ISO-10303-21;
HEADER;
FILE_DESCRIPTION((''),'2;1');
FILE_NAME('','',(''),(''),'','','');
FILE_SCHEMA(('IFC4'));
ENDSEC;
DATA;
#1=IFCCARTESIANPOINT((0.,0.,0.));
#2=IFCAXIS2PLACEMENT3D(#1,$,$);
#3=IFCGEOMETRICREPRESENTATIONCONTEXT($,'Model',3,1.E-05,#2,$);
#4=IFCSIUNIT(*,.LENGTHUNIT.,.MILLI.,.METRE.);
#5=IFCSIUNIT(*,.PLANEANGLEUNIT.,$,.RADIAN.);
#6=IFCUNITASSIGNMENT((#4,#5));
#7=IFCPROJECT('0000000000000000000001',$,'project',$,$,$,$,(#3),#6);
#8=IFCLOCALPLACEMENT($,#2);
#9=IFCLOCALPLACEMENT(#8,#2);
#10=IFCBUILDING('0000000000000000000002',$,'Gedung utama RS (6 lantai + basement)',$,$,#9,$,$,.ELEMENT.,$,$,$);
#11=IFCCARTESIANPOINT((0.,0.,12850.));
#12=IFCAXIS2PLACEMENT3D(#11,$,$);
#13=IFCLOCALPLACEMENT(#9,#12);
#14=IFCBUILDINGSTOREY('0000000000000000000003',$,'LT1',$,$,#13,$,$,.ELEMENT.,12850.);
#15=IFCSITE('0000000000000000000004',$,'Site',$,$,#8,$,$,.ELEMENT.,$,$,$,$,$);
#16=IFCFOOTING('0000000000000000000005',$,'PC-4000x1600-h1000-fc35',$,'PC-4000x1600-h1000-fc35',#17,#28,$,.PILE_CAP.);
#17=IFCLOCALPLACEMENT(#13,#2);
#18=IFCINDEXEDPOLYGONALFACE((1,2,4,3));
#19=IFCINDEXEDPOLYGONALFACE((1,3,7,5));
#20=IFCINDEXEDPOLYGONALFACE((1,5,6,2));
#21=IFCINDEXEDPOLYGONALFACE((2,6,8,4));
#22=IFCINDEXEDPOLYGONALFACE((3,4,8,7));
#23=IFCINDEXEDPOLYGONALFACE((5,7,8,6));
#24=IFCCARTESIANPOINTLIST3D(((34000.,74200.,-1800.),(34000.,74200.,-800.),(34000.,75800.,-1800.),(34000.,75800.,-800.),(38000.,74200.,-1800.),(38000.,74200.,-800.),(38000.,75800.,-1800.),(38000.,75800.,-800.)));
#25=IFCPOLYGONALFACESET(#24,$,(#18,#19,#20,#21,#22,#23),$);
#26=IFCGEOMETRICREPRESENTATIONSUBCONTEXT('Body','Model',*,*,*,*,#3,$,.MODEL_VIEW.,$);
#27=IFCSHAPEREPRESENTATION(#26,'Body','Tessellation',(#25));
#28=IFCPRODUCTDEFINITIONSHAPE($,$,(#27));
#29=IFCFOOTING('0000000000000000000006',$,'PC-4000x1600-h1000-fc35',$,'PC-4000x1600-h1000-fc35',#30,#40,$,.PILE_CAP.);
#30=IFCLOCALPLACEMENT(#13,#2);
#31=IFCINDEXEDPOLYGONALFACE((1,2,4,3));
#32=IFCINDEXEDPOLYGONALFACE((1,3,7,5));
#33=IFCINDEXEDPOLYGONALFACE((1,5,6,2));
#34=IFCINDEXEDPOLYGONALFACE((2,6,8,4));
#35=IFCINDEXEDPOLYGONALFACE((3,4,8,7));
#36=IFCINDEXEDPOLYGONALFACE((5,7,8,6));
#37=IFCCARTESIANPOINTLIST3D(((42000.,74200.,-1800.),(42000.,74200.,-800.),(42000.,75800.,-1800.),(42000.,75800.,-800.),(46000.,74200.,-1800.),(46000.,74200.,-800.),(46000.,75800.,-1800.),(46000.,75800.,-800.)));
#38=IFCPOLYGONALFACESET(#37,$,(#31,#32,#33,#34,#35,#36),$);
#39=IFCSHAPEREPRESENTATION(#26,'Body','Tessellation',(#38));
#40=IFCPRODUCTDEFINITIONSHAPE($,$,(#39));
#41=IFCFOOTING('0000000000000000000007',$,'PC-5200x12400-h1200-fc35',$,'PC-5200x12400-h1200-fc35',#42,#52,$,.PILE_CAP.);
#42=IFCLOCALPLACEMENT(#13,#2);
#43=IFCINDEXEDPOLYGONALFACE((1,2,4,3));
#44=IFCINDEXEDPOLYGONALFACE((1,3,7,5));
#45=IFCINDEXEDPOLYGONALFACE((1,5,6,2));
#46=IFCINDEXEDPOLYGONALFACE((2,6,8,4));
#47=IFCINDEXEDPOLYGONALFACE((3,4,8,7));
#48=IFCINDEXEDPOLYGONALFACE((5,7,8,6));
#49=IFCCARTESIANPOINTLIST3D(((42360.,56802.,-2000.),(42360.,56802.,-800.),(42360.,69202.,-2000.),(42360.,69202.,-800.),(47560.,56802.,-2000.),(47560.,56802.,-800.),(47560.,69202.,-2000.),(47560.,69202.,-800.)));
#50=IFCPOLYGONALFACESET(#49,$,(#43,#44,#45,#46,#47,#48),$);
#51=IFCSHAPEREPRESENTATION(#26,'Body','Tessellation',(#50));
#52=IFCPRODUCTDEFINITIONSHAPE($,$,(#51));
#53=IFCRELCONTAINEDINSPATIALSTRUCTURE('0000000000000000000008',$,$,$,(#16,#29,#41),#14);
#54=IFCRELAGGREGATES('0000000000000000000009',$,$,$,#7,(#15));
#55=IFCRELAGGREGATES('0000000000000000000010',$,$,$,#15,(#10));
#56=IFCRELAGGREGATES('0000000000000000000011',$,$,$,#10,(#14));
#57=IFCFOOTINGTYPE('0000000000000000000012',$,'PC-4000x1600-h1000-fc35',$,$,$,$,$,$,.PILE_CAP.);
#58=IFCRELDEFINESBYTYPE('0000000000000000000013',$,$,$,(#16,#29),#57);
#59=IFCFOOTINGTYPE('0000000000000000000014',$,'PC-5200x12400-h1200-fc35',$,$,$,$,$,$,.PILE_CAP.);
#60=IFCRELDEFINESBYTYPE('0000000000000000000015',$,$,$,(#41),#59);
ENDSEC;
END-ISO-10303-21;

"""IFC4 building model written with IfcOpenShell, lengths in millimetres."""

from ifc_helpers import new_model, si_unit, frame, origin, origin_2d, place, context, subcontext, project, spatial, rectangle, extrude, material_profile, profile_set, profile_usage, type_object, element, save


model = new_model("IFC4")

# Units and contexts
model_context = context("Model", 3, precision=1e-05, world=origin())
body_context = subcontext(model_context, "Body", "Model", "MODEL_VIEW")
ifc_project = project(units=[si_unit("LENGTHUNIT", "METRE", prefix="MILLI"), si_unit("PLANEANGLEUNIT", "RADIAN")], contexts=[model_context])

# Site, building, storey
site_placement = place(None, origin())
site = spatial("IfcSite", under=ifc_project, at=site_placement, Name="Site", CompositionType="ELEMENT")
building_placement = place(site_placement, origin())
building = spatial("IfcBuilding", under=site, at=building_placement, Name="Gedung utama RS (6 lantai + basement)", CompositionType="ELEMENT")
storey_placement = place(building_placement, frame((0.0, 0.0, 12850.0)))
storey = spatial("IfcBuildingStorey", under=building, at=storey_placement, Name="LT1", CompositionType="ELEMENT", Elevation=12850.0)

# Footings
ifc_material_profile_1 = material_profile(None, rectangle(XDim=4000.0, YDim=1600.0, at=origin_2d()), Name="PC-4000x1600-h1000-fc35")
ifc_profile_set_1 = profile_set([ifc_material_profile_1], Name="PC-4000x1600-h1000-fc35")
ifc_profile_usage_1 = profile_usage(ifc_profile_set_1, cardinal=5)
footing_type_1 = type_object("IfcFootingType", Name="PC-4000x1600-h1000-fc35", PredefinedType="PILE_CAP", material=ifc_profile_set_1)
for number, where, z_axis, x_axis, name in (
    (1, (36000.0, 75000.0, -1800.0), (0.0, 0.0, 1.0), (1.0, 0.0, 0.0), "PC-4000x1600-h1000-fc35"),
    (2, (44000.0, 75000.0, -1800.0), (0.0, 0.0, 1.0), (1.0, 0.0, 0.0), "PC-4000x1600-h1000-fc35"),
):
    element("IfcFooting", number, at=place(storey_placement, frame(where, z_axis=z_axis, x_axis=x_axis)), inside=storey, type_object=footing_type_1, material=ifc_profile_usage_1, Name=name, ObjectType="PC-4000x1600-h1000-fc35", PredefinedType="PILE_CAP", context=body_context, shape_type="SweptSolid", body=[
        extrude(rectangle(XDim=4000.0, YDim=1600.0, at=origin_2d()), origin(), (0.0, 0.0, 1.0), 1000.0),
    ])
ifc_material_profile_2 = material_profile(None, rectangle(XDim=5200.0, YDim=12400.0, at=origin_2d()), Name="PC-5200x12400-h1200-fc35")
ifc_profile_set_2 = profile_set([ifc_material_profile_2], Name="PC-5200x12400-h1200-fc35")
ifc_profile_usage_2 = profile_usage(ifc_profile_set_2, cardinal=5)
footing_type_2 = type_object("IfcFootingType", Name="PC-5200x12400-h1200-fc35", PredefinedType="PILE_CAP", material=ifc_profile_set_2)
footing_placement = place(storey_placement, frame((44960.0, 63002.0, -2000.0), z_axis=(0.0, 0.0, 1.0), x_axis=(1.0, 0.0, 0.0)))
element("IfcFooting", 3, at=footing_placement, inside=storey, type_object=footing_type_2, material=ifc_profile_usage_2, Name="PC-5200x12400-h1200-fc35", ObjectType="PC-5200x12400-h1200-fc35", PredefinedType="PILE_CAP", context=body_context, shape_type="SweptSolid", body=[
    extrude(rectangle(XDim=5200.0, YDim=12400.0, at=origin_2d()), origin(), (0.0, 0.0, 1.0), 1200.0),
])

save(model, "model.ifc")
